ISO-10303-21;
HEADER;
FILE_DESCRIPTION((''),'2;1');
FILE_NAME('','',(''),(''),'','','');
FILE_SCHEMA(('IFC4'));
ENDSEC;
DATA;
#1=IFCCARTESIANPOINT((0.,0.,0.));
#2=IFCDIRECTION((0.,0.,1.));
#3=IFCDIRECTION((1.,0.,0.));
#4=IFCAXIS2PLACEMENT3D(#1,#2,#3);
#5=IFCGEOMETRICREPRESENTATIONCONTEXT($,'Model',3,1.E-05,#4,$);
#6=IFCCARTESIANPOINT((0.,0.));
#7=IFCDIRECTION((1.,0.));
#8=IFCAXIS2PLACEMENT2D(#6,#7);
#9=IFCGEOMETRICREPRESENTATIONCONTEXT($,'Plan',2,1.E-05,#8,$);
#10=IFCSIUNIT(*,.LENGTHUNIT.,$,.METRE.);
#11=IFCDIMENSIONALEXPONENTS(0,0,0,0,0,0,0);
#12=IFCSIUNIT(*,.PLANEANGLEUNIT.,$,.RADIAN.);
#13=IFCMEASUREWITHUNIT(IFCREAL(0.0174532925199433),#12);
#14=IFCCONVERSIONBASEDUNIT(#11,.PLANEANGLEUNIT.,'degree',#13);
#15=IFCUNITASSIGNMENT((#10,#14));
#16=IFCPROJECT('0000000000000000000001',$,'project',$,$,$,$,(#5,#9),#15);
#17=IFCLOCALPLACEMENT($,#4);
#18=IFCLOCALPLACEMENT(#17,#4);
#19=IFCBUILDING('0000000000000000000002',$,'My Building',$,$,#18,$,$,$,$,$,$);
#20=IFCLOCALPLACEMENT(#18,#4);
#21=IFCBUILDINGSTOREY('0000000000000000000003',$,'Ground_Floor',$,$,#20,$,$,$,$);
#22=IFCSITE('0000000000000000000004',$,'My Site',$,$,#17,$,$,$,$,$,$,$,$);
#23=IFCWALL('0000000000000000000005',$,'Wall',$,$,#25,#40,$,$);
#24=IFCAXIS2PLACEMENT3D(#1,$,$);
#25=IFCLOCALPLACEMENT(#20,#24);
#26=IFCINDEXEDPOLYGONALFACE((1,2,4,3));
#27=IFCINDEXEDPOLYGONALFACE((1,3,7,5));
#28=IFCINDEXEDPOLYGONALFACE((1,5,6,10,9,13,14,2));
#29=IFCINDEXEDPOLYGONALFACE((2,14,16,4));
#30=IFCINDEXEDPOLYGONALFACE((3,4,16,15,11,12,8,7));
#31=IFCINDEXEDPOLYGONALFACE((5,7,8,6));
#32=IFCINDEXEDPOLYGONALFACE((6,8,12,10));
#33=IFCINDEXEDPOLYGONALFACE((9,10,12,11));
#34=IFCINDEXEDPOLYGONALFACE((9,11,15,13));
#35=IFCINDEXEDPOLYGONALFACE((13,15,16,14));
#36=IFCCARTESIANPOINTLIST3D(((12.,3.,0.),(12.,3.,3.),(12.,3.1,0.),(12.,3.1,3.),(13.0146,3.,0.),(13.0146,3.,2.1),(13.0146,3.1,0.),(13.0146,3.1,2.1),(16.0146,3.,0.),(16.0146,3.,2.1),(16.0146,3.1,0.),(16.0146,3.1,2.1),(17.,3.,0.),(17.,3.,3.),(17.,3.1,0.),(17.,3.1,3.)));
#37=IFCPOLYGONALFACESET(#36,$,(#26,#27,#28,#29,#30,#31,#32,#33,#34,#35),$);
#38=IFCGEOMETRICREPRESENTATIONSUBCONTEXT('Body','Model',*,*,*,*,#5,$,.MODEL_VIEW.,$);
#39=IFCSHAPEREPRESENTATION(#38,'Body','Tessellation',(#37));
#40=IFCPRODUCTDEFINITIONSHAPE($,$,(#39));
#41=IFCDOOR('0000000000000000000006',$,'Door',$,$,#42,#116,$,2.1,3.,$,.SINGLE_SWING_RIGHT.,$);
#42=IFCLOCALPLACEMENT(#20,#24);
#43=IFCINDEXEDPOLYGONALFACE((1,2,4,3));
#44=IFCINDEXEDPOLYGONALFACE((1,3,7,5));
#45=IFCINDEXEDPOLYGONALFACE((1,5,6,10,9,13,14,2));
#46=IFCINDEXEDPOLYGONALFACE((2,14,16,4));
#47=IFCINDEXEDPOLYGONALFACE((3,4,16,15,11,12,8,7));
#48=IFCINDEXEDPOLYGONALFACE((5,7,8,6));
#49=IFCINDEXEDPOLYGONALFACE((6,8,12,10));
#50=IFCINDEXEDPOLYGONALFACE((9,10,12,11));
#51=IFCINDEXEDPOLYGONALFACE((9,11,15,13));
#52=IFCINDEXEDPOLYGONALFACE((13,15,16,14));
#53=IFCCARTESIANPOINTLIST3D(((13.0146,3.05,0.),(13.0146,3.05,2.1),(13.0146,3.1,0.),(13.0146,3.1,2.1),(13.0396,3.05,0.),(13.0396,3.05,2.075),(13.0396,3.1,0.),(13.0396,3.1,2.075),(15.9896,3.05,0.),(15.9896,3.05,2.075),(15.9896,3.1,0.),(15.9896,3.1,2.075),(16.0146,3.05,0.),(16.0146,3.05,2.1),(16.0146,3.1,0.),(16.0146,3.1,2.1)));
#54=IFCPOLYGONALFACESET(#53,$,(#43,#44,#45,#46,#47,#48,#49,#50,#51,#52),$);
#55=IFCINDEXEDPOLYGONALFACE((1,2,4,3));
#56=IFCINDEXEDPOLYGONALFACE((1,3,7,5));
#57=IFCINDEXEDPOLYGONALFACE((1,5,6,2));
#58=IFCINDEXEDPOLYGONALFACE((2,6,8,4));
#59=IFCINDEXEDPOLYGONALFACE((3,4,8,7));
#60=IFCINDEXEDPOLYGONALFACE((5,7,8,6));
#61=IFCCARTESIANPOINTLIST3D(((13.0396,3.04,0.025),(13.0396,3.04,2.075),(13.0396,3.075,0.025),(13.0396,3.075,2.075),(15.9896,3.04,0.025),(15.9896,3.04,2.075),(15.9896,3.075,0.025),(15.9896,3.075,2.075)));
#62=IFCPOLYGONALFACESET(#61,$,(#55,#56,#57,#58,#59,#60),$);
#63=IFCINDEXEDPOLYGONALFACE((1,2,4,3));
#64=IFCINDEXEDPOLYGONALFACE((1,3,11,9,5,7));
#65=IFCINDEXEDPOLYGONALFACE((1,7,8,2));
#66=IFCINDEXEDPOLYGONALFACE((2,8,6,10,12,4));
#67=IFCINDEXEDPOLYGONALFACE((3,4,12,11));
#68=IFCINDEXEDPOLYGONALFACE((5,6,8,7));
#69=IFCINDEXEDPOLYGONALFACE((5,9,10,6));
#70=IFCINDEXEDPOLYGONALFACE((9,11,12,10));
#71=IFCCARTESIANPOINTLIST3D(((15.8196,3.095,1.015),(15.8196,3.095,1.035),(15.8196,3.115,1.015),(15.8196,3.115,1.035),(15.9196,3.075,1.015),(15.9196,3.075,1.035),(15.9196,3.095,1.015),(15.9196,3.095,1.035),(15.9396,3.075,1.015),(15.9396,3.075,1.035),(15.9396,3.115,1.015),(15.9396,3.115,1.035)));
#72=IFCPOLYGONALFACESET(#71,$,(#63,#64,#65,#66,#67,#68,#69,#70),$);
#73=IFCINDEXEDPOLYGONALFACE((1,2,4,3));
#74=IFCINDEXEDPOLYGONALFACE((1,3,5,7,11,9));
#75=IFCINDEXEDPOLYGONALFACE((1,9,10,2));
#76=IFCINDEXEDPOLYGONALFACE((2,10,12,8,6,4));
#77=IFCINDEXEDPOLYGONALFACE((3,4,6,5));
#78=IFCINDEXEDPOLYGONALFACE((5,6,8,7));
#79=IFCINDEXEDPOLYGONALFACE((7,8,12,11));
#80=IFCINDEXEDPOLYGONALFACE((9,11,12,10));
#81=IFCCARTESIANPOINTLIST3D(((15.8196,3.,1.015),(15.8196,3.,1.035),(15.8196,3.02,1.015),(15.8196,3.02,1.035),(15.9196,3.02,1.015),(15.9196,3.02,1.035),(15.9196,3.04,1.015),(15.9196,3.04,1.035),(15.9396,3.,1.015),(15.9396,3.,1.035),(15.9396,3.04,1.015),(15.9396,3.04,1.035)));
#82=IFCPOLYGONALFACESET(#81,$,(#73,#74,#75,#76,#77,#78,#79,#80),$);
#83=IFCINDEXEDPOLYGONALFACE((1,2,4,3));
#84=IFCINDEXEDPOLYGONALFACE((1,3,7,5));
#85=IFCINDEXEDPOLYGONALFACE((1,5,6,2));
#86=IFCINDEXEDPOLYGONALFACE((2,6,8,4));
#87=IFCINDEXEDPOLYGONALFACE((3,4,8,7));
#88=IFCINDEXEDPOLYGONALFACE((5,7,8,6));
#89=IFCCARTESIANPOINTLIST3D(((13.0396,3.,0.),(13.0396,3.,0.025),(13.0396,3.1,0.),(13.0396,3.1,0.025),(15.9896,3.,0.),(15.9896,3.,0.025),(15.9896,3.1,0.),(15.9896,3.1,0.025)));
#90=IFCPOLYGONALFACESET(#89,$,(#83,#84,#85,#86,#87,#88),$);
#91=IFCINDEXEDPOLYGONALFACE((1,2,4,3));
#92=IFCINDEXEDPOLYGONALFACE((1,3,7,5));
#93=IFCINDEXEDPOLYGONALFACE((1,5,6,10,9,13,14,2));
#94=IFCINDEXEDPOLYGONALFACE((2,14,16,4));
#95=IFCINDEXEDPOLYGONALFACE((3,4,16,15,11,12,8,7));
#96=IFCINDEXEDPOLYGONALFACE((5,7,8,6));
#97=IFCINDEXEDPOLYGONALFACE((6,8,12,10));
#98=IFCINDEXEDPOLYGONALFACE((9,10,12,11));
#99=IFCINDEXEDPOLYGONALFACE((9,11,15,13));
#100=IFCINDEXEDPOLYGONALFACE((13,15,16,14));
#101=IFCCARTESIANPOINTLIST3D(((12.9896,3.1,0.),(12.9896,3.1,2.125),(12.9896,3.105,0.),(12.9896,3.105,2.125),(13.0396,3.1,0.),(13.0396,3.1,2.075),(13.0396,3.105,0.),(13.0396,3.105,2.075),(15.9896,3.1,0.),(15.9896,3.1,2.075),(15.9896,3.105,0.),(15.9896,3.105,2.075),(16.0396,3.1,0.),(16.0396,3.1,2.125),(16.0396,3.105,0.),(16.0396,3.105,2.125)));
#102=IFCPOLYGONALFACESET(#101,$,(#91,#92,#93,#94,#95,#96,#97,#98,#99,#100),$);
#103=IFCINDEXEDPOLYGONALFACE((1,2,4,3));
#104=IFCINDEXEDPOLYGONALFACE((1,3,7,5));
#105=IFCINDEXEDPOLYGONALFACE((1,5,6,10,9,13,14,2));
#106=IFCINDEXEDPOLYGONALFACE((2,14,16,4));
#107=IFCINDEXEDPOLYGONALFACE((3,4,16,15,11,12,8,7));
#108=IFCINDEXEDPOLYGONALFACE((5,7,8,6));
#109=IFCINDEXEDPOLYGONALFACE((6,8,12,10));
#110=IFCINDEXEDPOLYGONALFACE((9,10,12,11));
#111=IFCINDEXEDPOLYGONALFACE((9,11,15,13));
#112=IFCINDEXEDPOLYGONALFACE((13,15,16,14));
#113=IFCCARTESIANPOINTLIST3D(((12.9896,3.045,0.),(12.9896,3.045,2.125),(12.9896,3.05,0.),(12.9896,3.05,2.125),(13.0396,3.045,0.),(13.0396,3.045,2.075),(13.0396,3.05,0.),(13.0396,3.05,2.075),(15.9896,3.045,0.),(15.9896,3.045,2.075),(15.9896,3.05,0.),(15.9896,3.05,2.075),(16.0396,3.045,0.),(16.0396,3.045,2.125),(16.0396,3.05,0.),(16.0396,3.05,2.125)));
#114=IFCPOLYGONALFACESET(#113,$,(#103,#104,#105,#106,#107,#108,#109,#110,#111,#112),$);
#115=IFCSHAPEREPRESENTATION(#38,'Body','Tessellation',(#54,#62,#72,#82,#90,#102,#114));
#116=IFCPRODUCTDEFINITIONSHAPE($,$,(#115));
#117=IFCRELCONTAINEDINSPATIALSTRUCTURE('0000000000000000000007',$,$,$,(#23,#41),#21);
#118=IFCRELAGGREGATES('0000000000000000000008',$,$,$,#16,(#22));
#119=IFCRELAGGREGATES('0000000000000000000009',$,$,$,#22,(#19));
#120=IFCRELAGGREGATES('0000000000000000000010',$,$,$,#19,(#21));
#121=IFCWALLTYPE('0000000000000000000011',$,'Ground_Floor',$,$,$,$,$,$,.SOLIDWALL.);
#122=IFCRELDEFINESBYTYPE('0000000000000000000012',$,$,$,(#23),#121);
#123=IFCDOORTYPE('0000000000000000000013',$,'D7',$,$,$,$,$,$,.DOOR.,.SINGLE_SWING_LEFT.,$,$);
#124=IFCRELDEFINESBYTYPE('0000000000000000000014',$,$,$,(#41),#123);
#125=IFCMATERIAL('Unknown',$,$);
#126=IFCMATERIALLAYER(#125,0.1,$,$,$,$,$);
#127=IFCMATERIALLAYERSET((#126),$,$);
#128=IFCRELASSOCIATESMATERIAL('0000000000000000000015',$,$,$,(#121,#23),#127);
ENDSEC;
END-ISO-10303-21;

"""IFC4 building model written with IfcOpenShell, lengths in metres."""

from ifc_helpers import new_model, entity, si_unit, converted_unit, frame, origin_with_axes, origin_2d_with_axis, place, context, subcontext, project, spatial, line, indexed_curve, outline, extrude, shape, source, transform, mapped, material, layer, layer_set, layer_usage, type_object, type_shapes, element, fill, save


model = new_model("IFC4")

# Units and contexts
model_context = context("Model", 3, precision=1e-05, world=origin_with_axes())
plan_context = context("Plan", 2, precision=1e-05, world=origin_2d_with_axis())
body_context_1 = subcontext(model_context, "Body", "Model", "MODEL_VIEW")
body_context_2 = subcontext(plan_context, "Body", "Plan", "PLAN_VIEW")
ifc_project = project(units=[si_unit("LENGTHUNIT", "METRE"), converted_unit("PLANEANGLEUNIT", "degree", entity("IfcReal", 0.0174532925199433), si_unit("PLANEANGLEUNIT", "RADIAN"), dimensions=[0, 0, 0, 0, 0, 0, 0])], contexts=[model_context, plan_context])

# Site, building, storey
site_placement = place(None, origin_with_axes())
site = spatial("IfcSite", under=ifc_project, at=site_placement, Name="My Site")
building_placement = place(site_placement, origin_with_axes())
building = spatial("IfcBuilding", under=site, at=building_placement, Name="My Building")
storey_placement = place(building_placement, origin_with_axes())
storey = spatial("IfcBuildingStorey", under=building, at=storey_placement, Name="Ground_Floor")

# Shared definitions
ifc_material = material(Name="Unknown")

# Shared definitions
ifc_layer = layer(ifc_material, 0.1)
ifc_layer_set = layer_set([ifc_layer])
wall_type = type_object("IfcWallType", Name="Ground_Floor", PredefinedType="SOLIDWALL", material=ifc_layer_set)

# Wall, opening, door
ifc_layer_usage_1 = layer_usage(ifc_layer_set, "AXIS2", "POSITIVE", 0.0)
wall_1_placement = place(storey_placement, frame((12.0, 3.0, 0.0), z_axis=(0.0, 0.0, 1.0), x_axis=(1.0, 0.0, 0.0)))
wall_1 = element("IfcWall", 1, at=wall_1_placement, inside=storey, type_object=wall_type, material=ifc_layer_usage_1, Name="Wall", context=body_context_1, shape_type="SweptSolid", body=[
    extrude(outline(indexed_curve([(0.0, 0.0), (0.0, 0.1), (5.0, 0.1), (5.0, 0.0)], segments=[line(1, 2, 3, 4, 1)])), origin_with_axes(), (0.0, 0.0, 1.0), 3.0),
])
shared_shape_1 = source(origin_with_axes(), body_context_1, "Body", "SweptSolid", [
    extrude(outline(indexed_curve([(0.0, 0.0), (3.0, 0.0), (3.0, 2.1), (0.0, 2.1)], segments=[line(1, 2, 3, 4, 1)])), frame((0.0, -0.6, 0.0), z_axis=(0.0, -1.0, 0.0), x_axis=(1.0, 0.0, 0.0)), (0.0, 0.0, -1.0), 1.2),
])
opening_1_placement = place(wall_1_placement, frame((4.0146, 0.1, 0.0), z_axis=(0.0, 0.0, 1.0), x_axis=(-1.0, 0.0, 0.0)))
opening_1 = element("IfcOpeningElement", 2, at=opening_1_placement, cuts=wall_1, PredefinedType="OPENING", context=body_context_1, shape_type="MappedRepresentation", body=[
    mapped(shared_shape_1, transform((0.0, 0.0, 0.0), x_axis=(1.0, 0.0, 0.0), y_axis=(0.0, 1.0, 0.0), z_axis=(0.0, 0.0, 1.0), scale=1.0)),
])
door_type_1 = type_object("IfcDoorType", Name="D7", OperationType="SINGLE_SWING_LEFT", PredefinedType="DOOR")
shared_shape_2 = source(origin_with_axes(), body_context_1, "Body", "SweptSolid", [
    extrude(outline(indexed_curve([(0.0, 0.0), (0.0, 2.1), (3.0, 2.1), (3.0, 0.0), (2.975, 0.0), (2.975, 2.075), (0.025, 2.075), (0.025, 0.0)], segments=[line(1, 2, 3, 4, 5, 6, 7, 8, 1)])), frame((0.0, 0.0, 0.0), z_axis=(0.0, -1.0, 0.0), x_axis=(1.0, 0.0, 0.0)), (0.0, 0.0, -1.0), 0.05),
    extrude(outline(indexed_curve([(0.0, 0.0), (2.95, 0.0), (2.95, 0.035), (0.0, 0.035)], segments=[line(1, 2, 3, 4, 1)])), frame((0.025, 0.025, 0.025), z_axis=(0.0, 0.0, 1.0), x_axis=(1.0, 0.0, 0.0)), (0.0, 0.0, 1.0), 2.05),
    extrude(outline(indexed_curve([(0.0, 0.0), (0.0, -0.04), (0.12, -0.04), (0.12, -0.02), (0.02, -0.02), (0.02, 0.0)], segments=[line(1, 2, 3, 4, 5, 6, 1)])), frame((0.075, 0.025, 1.015), z_axis=(0.0, 0.0, 1.0), x_axis=(1.0, 0.0, 0.0)), (0.0, 0.0, 1.0), 0.02),
    extrude(outline(indexed_curve([(0.0, 0.0), (0.0, 0.04), (0.12, 0.04), (0.12, 0.02), (0.02, 0.02), (0.02, 0.0)], segments=[line(1, 2, 3, 4, 5, 6, 1)])), frame((0.075, 0.06, 1.015), z_axis=(0.0, 0.0, 1.0), x_axis=(1.0, 0.0, 0.0)), (0.0, 0.0, 1.0), 0.02),
    extrude(outline(indexed_curve([(0.0, 0.0), (2.95, 0.0), (2.95, 0.1), (0.0, 0.1)], segments=[line(1, 2, 3, 4, 1)])), frame((0.025, 0.0, 0.0), z_axis=(0.0, 0.0, 1.0), x_axis=(1.0, 0.0, 0.0)), (0.0, 0.0, 1.0), 0.025),
    extrude(outline(indexed_curve([(0.0, 0.0), (0.0, 2.125), (3.05, 2.125), (3.05, 0.0), (3.0, 0.0), (3.0, 2.075), (0.05, 2.075), (0.05, 0.0)], segments=[line(1, 2, 3, 4, 5, 6, 7, 8, 1)])), frame((-0.025, -0.005, 0.0), z_axis=(0.0, -1.0, 0.0), x_axis=(1.0, 0.0, 0.0)), (0.0, 0.0, -1.0), 0.005),
    extrude(outline(indexed_curve([(0.0, 0.0), (0.0, 2.125), (3.05, 2.125), (3.05, 0.0), (3.0, 0.0), (3.0, 2.075), (0.05, 2.075), (0.05, 0.0)], segments=[line(1, 2, 3, 4, 5, 6, 7, 8, 1)])), frame((-0.025, 0.05, 0.0), z_axis=(0.0, -1.0, 0.0), x_axis=(1.0, 0.0, 0.0)), (0.0, 0.0, -1.0), 0.005),
])
shared_shape_3 = source(origin_with_axes(), body_context_2, "Body", "Curve2D", [
    entity("IfcIndexedPolyCurve", entity("IfcCartesianPointList2D", [[0.0, 0.0], [0.025, 0.0], [0.025, 0.05], [0.0, 0.05]]), [entity("IfcLineIndex", [1, 2, 3, 4, 1])]),
    entity("IfcIndexedPolyCurve", entity("IfcCartesianPointList2D", [[3.0, 0.0], [2.975, 0.0], [2.975, 0.05], [3.0, 0.05]]), [entity("IfcLineIndex", [1, 2, 3, 4, 1])]),
    entity("IfcIndexedPolyCurve", entity("IfcCartesianPointList2D", [[2.975, 0.05], [2.975, -2.9], [2.94, -2.9]])),
    entity("IfcTrimmedCurve", entity("IfcEllipse", entity("IfcAxis2Placement2D", entity("IfcCartesianPoint", [2.94, 0.05]), entity("IfcDirection", [1.0, 0.0])), 2.915, 2.95), [entity("IfcCartesianPoint", [2.94, 3.0])], [entity("IfcCartesianPoint", [2.94, -2.9])], True, "CARTESIAN"),
    entity("IfcIndexedPolyCurve", entity("IfcCartesianPointList2D", [[2.975, 0.05], [2.94, 0.05], [2.94, 3.0], [2.975, 3.0]]), [entity("IfcLineIndex", [1, 2, 3, 4, 1])]),
])
type_shapes(door_type_1, [shared_shape_2, shared_shape_3])
door_1_placement = place(opening_1_placement, origin_with_axes())
door_1 = element("IfcDoor", 3, at=door_1_placement, inside=storey, type_object=door_type_1, Name="Door", OperationType="SINGLE_SWING_RIGHT", OverallHeight=2.1, OverallWidth=3.0, shapes=[
    shape(body_context_1, "Body", "MappedRepresentation", [mapped(shared_shape_2, transform((0.0, 0.0, 0.0), x_axis=(1.0, 0.0, 0.0), y_axis=(0.0, 1.0, 0.0), z_axis=(0.0, 0.0, 1.0), scale=1.0))]),
    shape(body_context_2, "Body", "MappedRepresentation", [mapped(shared_shape_3, transform((0.0, 0.0, 0.0), x_axis=(1.0, 0.0, 0.0), y_axis=(0.0, 1.0, 0.0), z_axis=(0.0, 0.0, 1.0), scale=1.0))]),
])
fill(opening_1, door_1)

save(model, "model.ifc")
